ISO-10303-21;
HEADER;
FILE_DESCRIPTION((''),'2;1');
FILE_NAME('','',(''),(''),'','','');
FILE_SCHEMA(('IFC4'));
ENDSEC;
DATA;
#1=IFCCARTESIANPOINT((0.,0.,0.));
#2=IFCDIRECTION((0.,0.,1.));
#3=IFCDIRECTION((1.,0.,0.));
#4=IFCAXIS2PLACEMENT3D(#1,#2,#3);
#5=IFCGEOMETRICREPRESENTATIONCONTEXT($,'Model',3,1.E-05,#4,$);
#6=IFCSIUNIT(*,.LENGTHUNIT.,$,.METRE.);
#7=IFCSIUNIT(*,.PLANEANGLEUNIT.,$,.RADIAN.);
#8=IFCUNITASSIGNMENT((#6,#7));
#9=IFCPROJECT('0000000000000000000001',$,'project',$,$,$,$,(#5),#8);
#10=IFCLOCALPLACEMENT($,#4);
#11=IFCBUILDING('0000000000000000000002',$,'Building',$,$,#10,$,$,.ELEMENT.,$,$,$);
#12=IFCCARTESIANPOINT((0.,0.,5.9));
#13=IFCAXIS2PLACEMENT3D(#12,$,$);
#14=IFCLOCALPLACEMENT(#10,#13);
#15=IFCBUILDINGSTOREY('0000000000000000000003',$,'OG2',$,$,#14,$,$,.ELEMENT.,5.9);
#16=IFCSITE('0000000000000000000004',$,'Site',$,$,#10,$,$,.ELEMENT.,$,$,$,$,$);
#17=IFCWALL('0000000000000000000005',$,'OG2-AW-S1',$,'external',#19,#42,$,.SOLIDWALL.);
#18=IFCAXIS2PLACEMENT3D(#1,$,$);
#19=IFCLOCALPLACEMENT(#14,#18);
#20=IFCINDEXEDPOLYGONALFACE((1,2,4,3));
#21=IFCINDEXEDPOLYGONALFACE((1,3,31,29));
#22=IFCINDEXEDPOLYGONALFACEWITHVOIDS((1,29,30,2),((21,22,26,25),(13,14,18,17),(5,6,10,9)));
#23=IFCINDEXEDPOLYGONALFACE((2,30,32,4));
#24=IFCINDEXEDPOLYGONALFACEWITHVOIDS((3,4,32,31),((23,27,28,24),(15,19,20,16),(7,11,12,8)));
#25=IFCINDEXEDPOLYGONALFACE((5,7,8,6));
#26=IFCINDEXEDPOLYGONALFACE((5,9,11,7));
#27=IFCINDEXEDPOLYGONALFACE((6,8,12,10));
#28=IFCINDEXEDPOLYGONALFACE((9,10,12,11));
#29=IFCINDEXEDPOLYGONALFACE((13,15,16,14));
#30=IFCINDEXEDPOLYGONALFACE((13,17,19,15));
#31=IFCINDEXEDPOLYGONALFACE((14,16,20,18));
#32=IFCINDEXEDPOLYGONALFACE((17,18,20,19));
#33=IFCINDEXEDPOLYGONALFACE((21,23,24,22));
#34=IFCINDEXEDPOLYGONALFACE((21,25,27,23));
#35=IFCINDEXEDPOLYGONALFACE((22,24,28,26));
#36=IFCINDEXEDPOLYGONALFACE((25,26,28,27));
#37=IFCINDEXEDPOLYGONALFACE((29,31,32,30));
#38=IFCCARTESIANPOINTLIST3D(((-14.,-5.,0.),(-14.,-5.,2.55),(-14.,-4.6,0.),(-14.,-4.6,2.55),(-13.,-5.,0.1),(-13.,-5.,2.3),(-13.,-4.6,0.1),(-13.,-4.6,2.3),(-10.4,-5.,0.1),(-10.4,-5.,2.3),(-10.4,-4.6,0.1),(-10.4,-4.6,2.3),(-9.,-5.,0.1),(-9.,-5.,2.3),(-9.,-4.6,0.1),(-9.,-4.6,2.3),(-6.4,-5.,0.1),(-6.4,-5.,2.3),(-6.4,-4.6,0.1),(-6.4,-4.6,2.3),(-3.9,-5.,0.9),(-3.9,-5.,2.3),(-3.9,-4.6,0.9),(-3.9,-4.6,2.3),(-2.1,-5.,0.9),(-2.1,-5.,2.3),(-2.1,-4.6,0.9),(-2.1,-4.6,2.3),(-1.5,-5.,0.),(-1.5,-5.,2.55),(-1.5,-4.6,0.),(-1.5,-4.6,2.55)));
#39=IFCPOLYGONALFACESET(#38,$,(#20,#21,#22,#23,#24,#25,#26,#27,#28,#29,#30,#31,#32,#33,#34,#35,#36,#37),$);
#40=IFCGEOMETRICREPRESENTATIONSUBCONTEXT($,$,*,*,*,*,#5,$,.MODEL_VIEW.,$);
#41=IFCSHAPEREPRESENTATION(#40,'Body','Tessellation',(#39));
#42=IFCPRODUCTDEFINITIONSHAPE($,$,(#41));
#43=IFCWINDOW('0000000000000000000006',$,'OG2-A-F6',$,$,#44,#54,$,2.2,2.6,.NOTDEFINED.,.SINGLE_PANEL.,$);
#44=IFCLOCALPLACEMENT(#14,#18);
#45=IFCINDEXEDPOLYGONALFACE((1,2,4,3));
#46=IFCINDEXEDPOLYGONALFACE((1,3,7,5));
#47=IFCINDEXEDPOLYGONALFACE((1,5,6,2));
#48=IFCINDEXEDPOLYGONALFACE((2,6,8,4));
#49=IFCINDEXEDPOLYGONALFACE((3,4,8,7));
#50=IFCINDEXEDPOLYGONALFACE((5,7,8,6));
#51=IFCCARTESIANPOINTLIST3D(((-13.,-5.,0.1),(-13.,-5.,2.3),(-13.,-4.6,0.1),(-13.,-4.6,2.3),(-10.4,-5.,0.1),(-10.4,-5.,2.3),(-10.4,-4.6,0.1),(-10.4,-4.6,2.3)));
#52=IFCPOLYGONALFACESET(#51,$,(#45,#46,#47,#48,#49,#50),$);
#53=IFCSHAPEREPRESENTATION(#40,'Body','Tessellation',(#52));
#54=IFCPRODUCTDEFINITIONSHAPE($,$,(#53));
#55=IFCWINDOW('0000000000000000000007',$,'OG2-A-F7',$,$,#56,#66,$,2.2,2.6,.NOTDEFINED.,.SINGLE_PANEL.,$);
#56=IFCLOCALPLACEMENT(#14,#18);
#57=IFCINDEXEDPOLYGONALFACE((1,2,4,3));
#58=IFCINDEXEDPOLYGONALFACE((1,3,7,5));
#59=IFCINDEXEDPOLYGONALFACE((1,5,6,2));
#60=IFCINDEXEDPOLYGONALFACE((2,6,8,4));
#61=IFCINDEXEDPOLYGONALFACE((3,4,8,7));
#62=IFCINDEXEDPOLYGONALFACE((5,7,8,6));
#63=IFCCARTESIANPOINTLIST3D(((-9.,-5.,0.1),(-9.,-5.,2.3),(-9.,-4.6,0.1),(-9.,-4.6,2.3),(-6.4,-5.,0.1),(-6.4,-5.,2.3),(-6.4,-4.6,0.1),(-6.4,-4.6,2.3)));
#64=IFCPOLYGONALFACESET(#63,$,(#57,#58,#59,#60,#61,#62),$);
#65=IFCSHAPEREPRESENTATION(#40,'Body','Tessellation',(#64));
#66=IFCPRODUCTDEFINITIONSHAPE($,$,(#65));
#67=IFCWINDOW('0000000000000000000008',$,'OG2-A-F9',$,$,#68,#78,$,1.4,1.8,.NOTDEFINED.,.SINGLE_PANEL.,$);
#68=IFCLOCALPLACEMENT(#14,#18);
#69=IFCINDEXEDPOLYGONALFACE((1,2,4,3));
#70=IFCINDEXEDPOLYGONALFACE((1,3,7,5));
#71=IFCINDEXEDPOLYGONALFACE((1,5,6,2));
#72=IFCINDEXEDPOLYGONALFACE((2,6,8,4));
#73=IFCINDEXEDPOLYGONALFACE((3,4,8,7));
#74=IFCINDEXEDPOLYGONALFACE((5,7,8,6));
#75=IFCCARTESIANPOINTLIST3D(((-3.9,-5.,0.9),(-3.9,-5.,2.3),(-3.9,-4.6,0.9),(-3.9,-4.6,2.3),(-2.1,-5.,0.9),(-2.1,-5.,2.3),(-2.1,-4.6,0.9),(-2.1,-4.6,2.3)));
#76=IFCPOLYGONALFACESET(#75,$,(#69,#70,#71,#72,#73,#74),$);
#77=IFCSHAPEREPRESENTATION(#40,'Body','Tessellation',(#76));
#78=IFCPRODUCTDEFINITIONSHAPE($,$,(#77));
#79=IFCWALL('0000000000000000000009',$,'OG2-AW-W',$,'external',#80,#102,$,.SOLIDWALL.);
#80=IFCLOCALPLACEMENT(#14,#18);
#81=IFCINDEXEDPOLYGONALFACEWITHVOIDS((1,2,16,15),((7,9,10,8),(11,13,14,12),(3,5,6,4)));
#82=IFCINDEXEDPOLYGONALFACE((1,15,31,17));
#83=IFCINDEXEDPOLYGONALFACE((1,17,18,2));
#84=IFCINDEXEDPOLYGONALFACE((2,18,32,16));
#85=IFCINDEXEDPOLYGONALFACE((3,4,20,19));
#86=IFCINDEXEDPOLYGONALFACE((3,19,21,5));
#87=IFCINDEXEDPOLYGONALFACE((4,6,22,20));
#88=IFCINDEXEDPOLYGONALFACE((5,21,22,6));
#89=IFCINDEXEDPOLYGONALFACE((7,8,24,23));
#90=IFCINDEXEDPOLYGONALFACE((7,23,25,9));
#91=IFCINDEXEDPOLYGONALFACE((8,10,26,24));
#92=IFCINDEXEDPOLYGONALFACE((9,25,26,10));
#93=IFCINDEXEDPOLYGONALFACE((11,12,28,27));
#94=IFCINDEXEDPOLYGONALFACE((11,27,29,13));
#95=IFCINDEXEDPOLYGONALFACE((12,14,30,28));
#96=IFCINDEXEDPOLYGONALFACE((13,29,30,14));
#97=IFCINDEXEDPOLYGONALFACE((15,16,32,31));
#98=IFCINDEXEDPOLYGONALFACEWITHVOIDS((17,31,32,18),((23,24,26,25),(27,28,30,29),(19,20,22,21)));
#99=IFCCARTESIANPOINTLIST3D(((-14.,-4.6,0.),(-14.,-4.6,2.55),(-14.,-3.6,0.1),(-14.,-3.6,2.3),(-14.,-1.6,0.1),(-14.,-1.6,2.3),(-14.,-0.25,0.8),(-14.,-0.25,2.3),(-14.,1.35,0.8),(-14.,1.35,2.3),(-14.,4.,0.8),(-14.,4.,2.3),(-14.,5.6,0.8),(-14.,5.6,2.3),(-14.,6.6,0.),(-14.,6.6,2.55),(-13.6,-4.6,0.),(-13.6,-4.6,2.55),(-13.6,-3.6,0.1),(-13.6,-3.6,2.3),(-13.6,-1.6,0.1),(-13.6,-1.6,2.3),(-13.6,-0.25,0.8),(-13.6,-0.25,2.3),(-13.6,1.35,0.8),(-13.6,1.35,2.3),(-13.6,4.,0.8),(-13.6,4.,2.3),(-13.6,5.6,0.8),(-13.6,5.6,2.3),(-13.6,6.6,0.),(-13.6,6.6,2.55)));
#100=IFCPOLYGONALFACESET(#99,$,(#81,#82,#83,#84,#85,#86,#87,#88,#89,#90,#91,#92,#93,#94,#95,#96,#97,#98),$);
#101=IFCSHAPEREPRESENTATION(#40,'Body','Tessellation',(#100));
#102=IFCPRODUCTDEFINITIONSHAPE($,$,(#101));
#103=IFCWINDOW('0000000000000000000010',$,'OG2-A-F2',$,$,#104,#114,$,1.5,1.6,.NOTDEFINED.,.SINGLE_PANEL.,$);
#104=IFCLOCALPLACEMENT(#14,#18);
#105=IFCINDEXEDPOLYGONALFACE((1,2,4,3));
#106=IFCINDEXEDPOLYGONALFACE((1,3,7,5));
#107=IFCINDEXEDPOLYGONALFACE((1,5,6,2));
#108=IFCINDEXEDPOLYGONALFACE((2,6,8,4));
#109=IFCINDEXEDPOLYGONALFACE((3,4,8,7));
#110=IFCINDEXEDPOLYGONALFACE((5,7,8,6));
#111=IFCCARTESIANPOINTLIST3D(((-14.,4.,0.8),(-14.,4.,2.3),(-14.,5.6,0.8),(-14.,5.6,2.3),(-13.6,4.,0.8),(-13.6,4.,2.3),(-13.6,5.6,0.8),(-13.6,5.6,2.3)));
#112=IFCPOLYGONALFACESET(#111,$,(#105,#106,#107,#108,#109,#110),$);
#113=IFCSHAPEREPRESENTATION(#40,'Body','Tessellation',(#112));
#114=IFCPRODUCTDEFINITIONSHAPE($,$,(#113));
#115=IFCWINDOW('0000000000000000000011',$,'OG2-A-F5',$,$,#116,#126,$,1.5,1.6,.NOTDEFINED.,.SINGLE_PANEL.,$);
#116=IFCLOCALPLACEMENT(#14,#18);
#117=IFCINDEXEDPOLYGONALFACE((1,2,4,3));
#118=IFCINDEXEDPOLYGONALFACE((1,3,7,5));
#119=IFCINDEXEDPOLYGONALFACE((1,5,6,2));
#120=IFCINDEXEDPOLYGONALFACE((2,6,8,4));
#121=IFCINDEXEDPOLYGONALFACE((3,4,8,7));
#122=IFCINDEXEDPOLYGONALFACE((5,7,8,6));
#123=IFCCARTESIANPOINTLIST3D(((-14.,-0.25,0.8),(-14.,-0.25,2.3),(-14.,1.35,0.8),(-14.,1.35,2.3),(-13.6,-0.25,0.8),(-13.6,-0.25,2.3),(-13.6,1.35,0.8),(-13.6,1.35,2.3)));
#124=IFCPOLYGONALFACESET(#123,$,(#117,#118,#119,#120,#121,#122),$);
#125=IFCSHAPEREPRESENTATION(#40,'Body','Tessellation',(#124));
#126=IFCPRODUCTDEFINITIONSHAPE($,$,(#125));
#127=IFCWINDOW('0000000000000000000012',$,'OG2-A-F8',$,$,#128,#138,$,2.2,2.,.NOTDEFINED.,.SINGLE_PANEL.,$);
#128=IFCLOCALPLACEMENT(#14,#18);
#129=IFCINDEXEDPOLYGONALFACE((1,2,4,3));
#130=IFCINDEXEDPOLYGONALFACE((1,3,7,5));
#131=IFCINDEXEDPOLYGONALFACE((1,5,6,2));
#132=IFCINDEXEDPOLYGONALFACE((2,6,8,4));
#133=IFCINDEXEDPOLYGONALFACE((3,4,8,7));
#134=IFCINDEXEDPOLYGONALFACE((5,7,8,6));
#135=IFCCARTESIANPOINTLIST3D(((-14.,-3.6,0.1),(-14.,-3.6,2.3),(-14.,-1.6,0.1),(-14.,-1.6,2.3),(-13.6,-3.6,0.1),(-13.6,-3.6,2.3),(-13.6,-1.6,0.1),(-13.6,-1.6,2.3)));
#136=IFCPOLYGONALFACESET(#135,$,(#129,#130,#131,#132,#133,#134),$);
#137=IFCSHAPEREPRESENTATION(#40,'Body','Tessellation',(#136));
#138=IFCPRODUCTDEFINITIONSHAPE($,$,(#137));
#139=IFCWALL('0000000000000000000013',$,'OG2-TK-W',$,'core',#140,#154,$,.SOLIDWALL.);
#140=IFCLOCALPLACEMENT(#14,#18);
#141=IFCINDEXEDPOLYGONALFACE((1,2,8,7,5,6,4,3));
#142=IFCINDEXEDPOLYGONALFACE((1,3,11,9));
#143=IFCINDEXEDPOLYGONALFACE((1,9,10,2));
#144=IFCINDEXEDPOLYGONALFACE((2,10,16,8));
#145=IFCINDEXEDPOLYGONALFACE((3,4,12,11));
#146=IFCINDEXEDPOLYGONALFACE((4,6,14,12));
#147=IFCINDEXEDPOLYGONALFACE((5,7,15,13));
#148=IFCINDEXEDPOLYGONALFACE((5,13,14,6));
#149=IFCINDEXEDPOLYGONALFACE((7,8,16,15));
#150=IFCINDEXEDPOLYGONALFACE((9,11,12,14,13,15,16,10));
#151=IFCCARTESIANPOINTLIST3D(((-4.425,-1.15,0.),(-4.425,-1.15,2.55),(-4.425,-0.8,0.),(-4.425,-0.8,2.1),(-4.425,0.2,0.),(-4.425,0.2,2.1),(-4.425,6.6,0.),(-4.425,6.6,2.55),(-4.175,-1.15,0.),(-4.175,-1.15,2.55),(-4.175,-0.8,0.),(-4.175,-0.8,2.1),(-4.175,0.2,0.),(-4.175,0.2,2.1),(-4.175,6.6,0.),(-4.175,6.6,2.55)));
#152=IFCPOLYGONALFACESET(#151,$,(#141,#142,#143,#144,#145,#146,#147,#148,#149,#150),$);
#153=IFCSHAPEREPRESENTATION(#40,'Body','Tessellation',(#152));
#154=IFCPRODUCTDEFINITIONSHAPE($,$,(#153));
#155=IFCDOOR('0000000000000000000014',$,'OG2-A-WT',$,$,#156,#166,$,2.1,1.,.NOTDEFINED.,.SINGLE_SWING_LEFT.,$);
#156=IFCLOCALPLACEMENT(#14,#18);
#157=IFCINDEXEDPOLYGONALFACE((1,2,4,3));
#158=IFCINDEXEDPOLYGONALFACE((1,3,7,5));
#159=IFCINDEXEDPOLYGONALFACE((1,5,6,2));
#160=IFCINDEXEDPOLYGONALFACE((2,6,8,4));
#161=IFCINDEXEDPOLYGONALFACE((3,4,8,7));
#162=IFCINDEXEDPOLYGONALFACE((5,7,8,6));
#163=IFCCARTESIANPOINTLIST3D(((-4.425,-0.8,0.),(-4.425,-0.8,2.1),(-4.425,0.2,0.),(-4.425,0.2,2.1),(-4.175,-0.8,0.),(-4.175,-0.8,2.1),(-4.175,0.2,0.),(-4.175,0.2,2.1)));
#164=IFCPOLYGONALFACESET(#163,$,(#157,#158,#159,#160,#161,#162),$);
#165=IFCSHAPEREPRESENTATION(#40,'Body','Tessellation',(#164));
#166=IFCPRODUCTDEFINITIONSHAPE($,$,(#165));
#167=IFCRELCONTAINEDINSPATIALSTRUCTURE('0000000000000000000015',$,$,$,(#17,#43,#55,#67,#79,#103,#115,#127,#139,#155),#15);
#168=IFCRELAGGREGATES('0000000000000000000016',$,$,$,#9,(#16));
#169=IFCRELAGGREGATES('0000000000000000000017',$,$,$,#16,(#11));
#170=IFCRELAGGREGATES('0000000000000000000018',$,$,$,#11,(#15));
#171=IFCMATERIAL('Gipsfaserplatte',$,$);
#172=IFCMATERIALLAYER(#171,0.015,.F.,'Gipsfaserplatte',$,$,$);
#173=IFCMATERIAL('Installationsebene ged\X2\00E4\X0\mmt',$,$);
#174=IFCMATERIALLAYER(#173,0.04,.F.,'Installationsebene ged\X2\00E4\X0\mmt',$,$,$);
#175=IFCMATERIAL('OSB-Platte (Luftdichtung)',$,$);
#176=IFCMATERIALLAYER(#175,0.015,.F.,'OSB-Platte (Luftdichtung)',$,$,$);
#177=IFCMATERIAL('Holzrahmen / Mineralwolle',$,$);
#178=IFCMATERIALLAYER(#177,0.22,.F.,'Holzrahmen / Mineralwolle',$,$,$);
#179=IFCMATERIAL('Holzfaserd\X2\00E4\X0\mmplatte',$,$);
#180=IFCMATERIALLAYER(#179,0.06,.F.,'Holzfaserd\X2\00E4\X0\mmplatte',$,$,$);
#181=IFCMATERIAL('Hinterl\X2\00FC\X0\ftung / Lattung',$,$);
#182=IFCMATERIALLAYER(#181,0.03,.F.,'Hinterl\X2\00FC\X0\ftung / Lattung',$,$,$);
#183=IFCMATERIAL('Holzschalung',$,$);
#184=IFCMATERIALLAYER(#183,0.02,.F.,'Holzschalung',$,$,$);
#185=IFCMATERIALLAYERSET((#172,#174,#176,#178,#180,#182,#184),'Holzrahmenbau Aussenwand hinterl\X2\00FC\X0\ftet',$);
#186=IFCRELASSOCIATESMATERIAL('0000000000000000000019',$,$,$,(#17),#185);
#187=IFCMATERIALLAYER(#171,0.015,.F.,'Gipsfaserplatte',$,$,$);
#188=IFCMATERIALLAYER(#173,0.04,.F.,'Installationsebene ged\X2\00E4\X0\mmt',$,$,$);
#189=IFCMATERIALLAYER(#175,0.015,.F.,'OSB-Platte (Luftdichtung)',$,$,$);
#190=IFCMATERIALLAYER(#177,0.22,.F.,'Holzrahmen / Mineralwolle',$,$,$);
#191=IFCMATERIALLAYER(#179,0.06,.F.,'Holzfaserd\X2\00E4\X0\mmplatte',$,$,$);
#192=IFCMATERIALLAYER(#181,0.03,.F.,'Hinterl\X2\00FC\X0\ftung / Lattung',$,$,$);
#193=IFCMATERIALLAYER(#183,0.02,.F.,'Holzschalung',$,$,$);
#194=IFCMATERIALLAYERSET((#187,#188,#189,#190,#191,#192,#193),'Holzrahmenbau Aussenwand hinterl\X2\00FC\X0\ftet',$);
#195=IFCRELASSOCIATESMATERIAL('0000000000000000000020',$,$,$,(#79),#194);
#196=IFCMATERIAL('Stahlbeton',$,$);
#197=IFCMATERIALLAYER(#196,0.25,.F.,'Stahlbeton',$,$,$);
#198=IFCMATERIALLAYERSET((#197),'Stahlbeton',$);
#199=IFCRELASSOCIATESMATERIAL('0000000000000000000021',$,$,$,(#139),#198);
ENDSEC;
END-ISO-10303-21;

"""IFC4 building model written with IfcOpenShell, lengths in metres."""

from ifc_helpers import new_model, si_unit, frame, frame_2d, origin, origin_with_axes, place, context, subcontext, project, spatial, rectangle, extrude, material, layer, layer_set, element, fill, save


model = new_model("IFC4")

# Units and contexts
model_context = context("Model", 3, precision=1e-05, world=origin_with_axes())
sub_context = subcontext(model_context, None, None, "MODEL_VIEW")
ifc_project = project(units=[si_unit("LENGTHUNIT", "METRE"), si_unit("PLANEANGLEUNIT", "RADIAN")], contexts=[model_context])

# Site, building, storey
placement = place(None, origin_with_axes())
site = spatial("IfcSite", under=ifc_project, at=placement, Name="Site", CompositionType="ELEMENT")
building = spatial("IfcBuilding", under=site, at=placement, Name="Building", CompositionType="ELEMENT")
storey_placement = place(placement, frame((0.0, 0.0, 5.9)))
storey = spatial("IfcBuildingStorey", under=building, at=storey_placement, Name="OG2", CompositionType="ELEMENT", Elevation=5.9)

# Walls, openings, windows
ifc_material_1 = material(Name="Gipsfaserplatte")
ifc_layer_1 = layer(ifc_material_1, 0.015, ventilated=False, Name="Gipsfaserplatte")
ifc_material_2 = material(Name="Installationsebene gedämmt")
ifc_layer_2 = layer(ifc_material_2, 0.04, ventilated=False, Name="Installationsebene gedämmt")
ifc_material_3 = material(Name="OSB-Platte (Luftdichtung)")
ifc_layer_3 = layer(ifc_material_3, 0.015, ventilated=False, Name="OSB-Platte (Luftdichtung)")
ifc_material_4 = material(Name="Holzrahmen / Mineralwolle")
ifc_layer_4 = layer(ifc_material_4, 0.22, ventilated=False, Name="Holzrahmen / Mineralwolle")
ifc_material_5 = material(Name="Holzfaserdämmplatte")
ifc_layer_5 = layer(ifc_material_5, 0.06, ventilated=False, Name="Holzfaserdämmplatte")
ifc_material_6 = material(Name="Hinterlüftung / Lattung")
ifc_layer_6 = layer(ifc_material_6, 0.03, ventilated=False, Name="Hinterlüftung / Lattung")
ifc_material_7 = material(Name="Holzschalung")
ifc_layer_7 = layer(ifc_material_7, 0.02, ventilated=False, Name="Holzschalung")
ifc_layer_set_1 = layer_set([ifc_layer_1, ifc_layer_2, ifc_layer_3, ifc_layer_4, ifc_layer_5, ifc_layer_6, ifc_layer_7], Name="Holzrahmenbau Aussenwand hinterlüftet")
wall_1_placement = place(storey_placement, frame((-14.0, -4.8, 0.0), z_axis=(0.0, 0.0, 1.0), x_axis=(1.0, 0.0, 0.0)))
wall_1 = element("IfcWall", 1, at=wall_1_placement, inside=storey, material=ifc_layer_set_1, Name="OG2-AW-S1", ObjectType="external", PredefinedType="SOLIDWALL", context=sub_context, shape_type="SweptSolid", body=[
    extrude(rectangle(XDim=12.5, YDim=0.4, at=frame_2d((6.25, 0.0))), origin(), (0.0, 0.0, 1.0), 2.55),
])
opening_1_placement = place(wall_1_placement, frame((2.3, 0.25, 0.1), z_axis=(0.0, -1.0, 0.0), x_axis=(1.0, 0.0, 0.0)))
opening_1 = element("IfcOpeningElement", 2, at=opening_1_placement, cuts=wall_1, PredefinedType="OPENING", context=sub_context, shape_type="SweptSolid", body=[
    extrude(rectangle(XDim=2.6, YDim=2.2, at=frame_2d((0.0, 1.1))), origin(), (0.0, 0.0, 1.0), 0.5),
])
opening_2_placement = place(wall_1_placement, frame((6.3, 0.25, 0.1), z_axis=(0.0, -1.0, 0.0), x_axis=(1.0, 0.0, 0.0)))
opening_2 = element("IfcOpeningElement", 3, at=opening_2_placement, cuts=wall_1, PredefinedType="OPENING", context=sub_context, shape_type="SweptSolid", body=[
    extrude(rectangle(XDim=2.6, YDim=2.2, at=frame_2d((0.0, 1.1))), origin(), (0.0, 0.0, 1.0), 0.5),
])
opening_3_placement = place(wall_1_placement, frame((11.0, 0.25, 0.9), z_axis=(0.0, -1.0, 0.0), x_axis=(1.0, 0.0, 0.0)))
opening_3 = element("IfcOpeningElement", 4, at=opening_3_placement, cuts=wall_1, PredefinedType="OPENING", context=sub_context, shape_type="SweptSolid", body=[
    extrude(rectangle(XDim=1.8, YDim=1.4, at=frame_2d((0.0, 0.7))), origin(), (0.0, 0.0, 1.0), 0.5),
])
window_1_placement = place(wall_1_placement, frame((2.3, 0.2, 0.1), z_axis=(0.0, -1.0, 0.0), x_axis=(1.0, 0.0, 0.0)))
window_1 = element("IfcWindow", 5, at=window_1_placement, inside=storey, Name="OG2-A-F6", OverallHeight=2.2, OverallWidth=2.6, PartitioningType="SINGLE_PANEL", PredefinedType="NOTDEFINED", context=sub_context, shape_type="SweptSolid", body=[
    extrude(rectangle(XDim=2.6, YDim=2.2, at=frame_2d((0.0, 1.1))), origin(), (0.0, 0.0, 1.0), 0.4),
])
fill(opening_1, window_1)
window_2_placement = place(wall_1_placement, frame((6.3, 0.2, 0.1), z_axis=(0.0, -1.0, 0.0), x_axis=(1.0, 0.0, 0.0)))
window_2 = element("IfcWindow", 6, at=window_2_placement, inside=storey, Name="OG2-A-F7", OverallHeight=2.2, OverallWidth=2.6, PartitioningType="SINGLE_PANEL", PredefinedType="NOTDEFINED", context=sub_context, shape_type="SweptSolid", body=[
    extrude(rectangle(XDim=2.6, YDim=2.2, at=frame_2d((0.0, 1.1))), origin(), (0.0, 0.0, 1.0), 0.4),
])
fill(opening_2, window_2)
window_3_placement = place(wall_1_placement, frame((11.0, 0.2, 0.9), z_axis=(0.0, -1.0, 0.0), x_axis=(1.0, 0.0, 0.0)))
window_3 = element("IfcWindow", 7, at=window_3_placement, inside=storey, Name="OG2-A-F9", OverallHeight=1.4, OverallWidth=1.8, PartitioningType="SINGLE_PANEL", PredefinedType="NOTDEFINED", context=sub_context, shape_type="SweptSolid", body=[
    extrude(rectangle(XDim=1.8, YDim=1.4, at=frame_2d((0.0, 0.7))), origin(), (0.0, 0.0, 1.0), 0.4),
])
fill(opening_3, window_3)
ifc_layer_8 = layer(ifc_material_1, 0.015, ventilated=False, Name="Gipsfaserplatte")
ifc_layer_9 = layer(ifc_material_2, 0.04, ventilated=False, Name="Installationsebene gedämmt")
ifc_layer_10 = layer(ifc_material_3, 0.015, ventilated=False, Name="OSB-Platte (Luftdichtung)")
ifc_layer_11 = layer(ifc_material_4, 0.22, ventilated=False, Name="Holzrahmen / Mineralwolle")
ifc_layer_12 = layer(ifc_material_5, 0.06, ventilated=False, Name="Holzfaserdämmplatte")
ifc_layer_13 = layer(ifc_material_6, 0.03, ventilated=False, Name="Hinterlüftung / Lattung")
ifc_layer_14 = layer(ifc_material_7, 0.02, ventilated=False, Name="Holzschalung")
ifc_layer_set_2 = layer_set([ifc_layer_8, ifc_layer_9, ifc_layer_10, ifc_layer_11, ifc_layer_12, ifc_layer_13, ifc_layer_14], Name="Holzrahmenbau Aussenwand hinterlüftet")
wall_2_placement = place(storey_placement, frame((-13.8, -4.6, 0.0), z_axis=(0.0, 0.0, 1.0), x_axis=(0.0, 1.0, 0.0)))
wall_2 = element("IfcWall", 8, at=wall_2_placement, inside=storey, material=ifc_layer_set_2, Name="OG2-AW-W", ObjectType="external", PredefinedType="SOLIDWALL", context=sub_context, shape_type="SweptSolid", body=[
    extrude(rectangle(XDim=11.2, YDim=0.4, at=frame_2d((5.6, 0.0))), origin(), (0.0, 0.0, 1.0), 2.55),
])
opening_4_placement = place(wall_2_placement, frame((9.4, 0.25, 0.8), z_axis=(0.0, -1.0, 0.0), x_axis=(1.0, 0.0, 0.0)))
opening_4 = element("IfcOpeningElement", 9, at=opening_4_placement, cuts=wall_2, PredefinedType="OPENING", context=sub_context, shape_type="SweptSolid", body=[
    extrude(rectangle(XDim=1.6, YDim=1.5, at=frame_2d((0.0, 0.75))), origin(), (0.0, 0.0, 1.0), 0.5),
])
opening_5_placement = place(wall_2_placement, frame((5.15, 0.25, 0.8), z_axis=(0.0, -1.0, 0.0), x_axis=(1.0, 0.0, 0.0)))
opening_5 = element("IfcOpeningElement", 10, at=opening_5_placement, cuts=wall_2, PredefinedType="OPENING", context=sub_context, shape_type="SweptSolid", body=[
    extrude(rectangle(XDim=1.6, YDim=1.5, at=frame_2d((0.0, 0.75))), origin(), (0.0, 0.0, 1.0), 0.5),
])
opening_6_placement = place(wall_2_placement, frame((2.0, 0.25, 0.1), z_axis=(0.0, -1.0, 0.0), x_axis=(1.0, 0.0, 0.0)))
opening_6 = element("IfcOpeningElement", 11, at=opening_6_placement, cuts=wall_2, PredefinedType="OPENING", context=sub_context, shape_type="SweptSolid", body=[
    extrude(rectangle(XDim=2.0, YDim=2.2, at=frame_2d((0.0, 1.1))), origin(), (0.0, 0.0, 1.0), 0.5),
])
window_4_placement = place(wall_2_placement, frame((9.4, 0.2, 0.8), z_axis=(0.0, -1.0, 0.0), x_axis=(1.0, 0.0, 0.0)))
window_4 = element("IfcWindow", 12, at=window_4_placement, inside=storey, Name="OG2-A-F2", OverallHeight=1.5, OverallWidth=1.6, PartitioningType="SINGLE_PANEL", PredefinedType="NOTDEFINED", context=sub_context, shape_type="SweptSolid", body=[
    extrude(rectangle(XDim=1.6, YDim=1.5, at=frame_2d((0.0, 0.75))), origin(), (0.0, 0.0, 1.0), 0.4),
])
fill(opening_4, window_4)
window_5_placement = place(wall_2_placement, frame((5.15, 0.2, 0.8), z_axis=(0.0, -1.0, 0.0), x_axis=(1.0, 0.0, 0.0)))
window_5 = element("IfcWindow", 13, at=window_5_placement, inside=storey, Name="OG2-A-F5", OverallHeight=1.5, OverallWidth=1.6, PartitioningType="SINGLE_PANEL", PredefinedType="NOTDEFINED", context=sub_context, shape_type="SweptSolid", body=[
    extrude(rectangle(XDim=1.6, YDim=1.5, at=frame_2d((0.0, 0.75))), origin(), (0.0, 0.0, 1.0), 0.4),
])
fill(opening_5, window_5)
window_6_placement = place(wall_2_placement, frame((2.0, 0.2, 0.1), z_axis=(0.0, -1.0, 0.0), x_axis=(1.0, 0.0, 0.0)))
window_6 = element("IfcWindow", 14, at=window_6_placement, inside=storey, Name="OG2-A-F8", OverallHeight=2.2, OverallWidth=2.0, PartitioningType="SINGLE_PANEL", PredefinedType="NOTDEFINED", context=sub_context, shape_type="SweptSolid", body=[
    extrude(rectangle(XDim=2.0, YDim=2.2, at=frame_2d((0.0, 1.1))), origin(), (0.0, 0.0, 1.0), 0.4),
])
fill(opening_6, window_6)

# Wall, opening, door
ifc_material_8 = material(Name="Stahlbeton")
ifc_layer_15 = layer(ifc_material_8, 0.25, ventilated=False, Name="Stahlbeton")
ifc_layer_set_3 = layer_set([ifc_layer_15], Name="Stahlbeton")
wall_3_placement = place(storey_placement, frame((-4.3, -1.15, 0.0), z_axis=(0.0, 0.0, 1.0), x_axis=(0.0, 1.0, 0.0)))
wall_3 = element("IfcWall", 15, at=wall_3_placement, inside=storey, material=ifc_layer_set_3, Name="OG2-TK-W", ObjectType="core", PredefinedType="SOLIDWALL", context=sub_context, shape_type="SweptSolid", body=[
    extrude(rectangle(XDim=7.75, YDim=0.25, at=frame_2d((3.875, 0.0))), origin(), (0.0, 0.0, 1.0), 2.55),
])
opening_7_placement = place(wall_3_placement, frame((0.85, 0.175, 0.0), z_axis=(0.0, -1.0, 0.0), x_axis=(1.0, 0.0, 0.0)))
opening_7 = element("IfcOpeningElement", 16, at=opening_7_placement, cuts=wall_3, PredefinedType="OPENING", context=sub_context, shape_type="SweptSolid", body=[
    extrude(rectangle(XDim=1.0, YDim=2.1, at=frame_2d((0.0, 1.05))), origin(), (0.0, 0.0, 1.0), 0.35),
])
door_1_placement = place(wall_3_placement, frame((0.85, 0.125, 0.0), z_axis=(0.0, -1.0, 0.0), x_axis=(1.0, 0.0, 0.0)))
door_1 = element("IfcDoor", 17, at=door_1_placement, inside=storey, Name="OG2-A-WT", OperationType="SINGLE_SWING_LEFT", OverallHeight=2.1, OverallWidth=1.0, PredefinedType="NOTDEFINED", context=sub_context, shape_type="SweptSolid", body=[
    extrude(rectangle(XDim=1.0, YDim=2.1, at=frame_2d((0.0, 1.05))), origin(), (0.0, 0.0, 1.0), 0.25),
])
fill(opening_7, door_1)

save(model, "model.ifc")
